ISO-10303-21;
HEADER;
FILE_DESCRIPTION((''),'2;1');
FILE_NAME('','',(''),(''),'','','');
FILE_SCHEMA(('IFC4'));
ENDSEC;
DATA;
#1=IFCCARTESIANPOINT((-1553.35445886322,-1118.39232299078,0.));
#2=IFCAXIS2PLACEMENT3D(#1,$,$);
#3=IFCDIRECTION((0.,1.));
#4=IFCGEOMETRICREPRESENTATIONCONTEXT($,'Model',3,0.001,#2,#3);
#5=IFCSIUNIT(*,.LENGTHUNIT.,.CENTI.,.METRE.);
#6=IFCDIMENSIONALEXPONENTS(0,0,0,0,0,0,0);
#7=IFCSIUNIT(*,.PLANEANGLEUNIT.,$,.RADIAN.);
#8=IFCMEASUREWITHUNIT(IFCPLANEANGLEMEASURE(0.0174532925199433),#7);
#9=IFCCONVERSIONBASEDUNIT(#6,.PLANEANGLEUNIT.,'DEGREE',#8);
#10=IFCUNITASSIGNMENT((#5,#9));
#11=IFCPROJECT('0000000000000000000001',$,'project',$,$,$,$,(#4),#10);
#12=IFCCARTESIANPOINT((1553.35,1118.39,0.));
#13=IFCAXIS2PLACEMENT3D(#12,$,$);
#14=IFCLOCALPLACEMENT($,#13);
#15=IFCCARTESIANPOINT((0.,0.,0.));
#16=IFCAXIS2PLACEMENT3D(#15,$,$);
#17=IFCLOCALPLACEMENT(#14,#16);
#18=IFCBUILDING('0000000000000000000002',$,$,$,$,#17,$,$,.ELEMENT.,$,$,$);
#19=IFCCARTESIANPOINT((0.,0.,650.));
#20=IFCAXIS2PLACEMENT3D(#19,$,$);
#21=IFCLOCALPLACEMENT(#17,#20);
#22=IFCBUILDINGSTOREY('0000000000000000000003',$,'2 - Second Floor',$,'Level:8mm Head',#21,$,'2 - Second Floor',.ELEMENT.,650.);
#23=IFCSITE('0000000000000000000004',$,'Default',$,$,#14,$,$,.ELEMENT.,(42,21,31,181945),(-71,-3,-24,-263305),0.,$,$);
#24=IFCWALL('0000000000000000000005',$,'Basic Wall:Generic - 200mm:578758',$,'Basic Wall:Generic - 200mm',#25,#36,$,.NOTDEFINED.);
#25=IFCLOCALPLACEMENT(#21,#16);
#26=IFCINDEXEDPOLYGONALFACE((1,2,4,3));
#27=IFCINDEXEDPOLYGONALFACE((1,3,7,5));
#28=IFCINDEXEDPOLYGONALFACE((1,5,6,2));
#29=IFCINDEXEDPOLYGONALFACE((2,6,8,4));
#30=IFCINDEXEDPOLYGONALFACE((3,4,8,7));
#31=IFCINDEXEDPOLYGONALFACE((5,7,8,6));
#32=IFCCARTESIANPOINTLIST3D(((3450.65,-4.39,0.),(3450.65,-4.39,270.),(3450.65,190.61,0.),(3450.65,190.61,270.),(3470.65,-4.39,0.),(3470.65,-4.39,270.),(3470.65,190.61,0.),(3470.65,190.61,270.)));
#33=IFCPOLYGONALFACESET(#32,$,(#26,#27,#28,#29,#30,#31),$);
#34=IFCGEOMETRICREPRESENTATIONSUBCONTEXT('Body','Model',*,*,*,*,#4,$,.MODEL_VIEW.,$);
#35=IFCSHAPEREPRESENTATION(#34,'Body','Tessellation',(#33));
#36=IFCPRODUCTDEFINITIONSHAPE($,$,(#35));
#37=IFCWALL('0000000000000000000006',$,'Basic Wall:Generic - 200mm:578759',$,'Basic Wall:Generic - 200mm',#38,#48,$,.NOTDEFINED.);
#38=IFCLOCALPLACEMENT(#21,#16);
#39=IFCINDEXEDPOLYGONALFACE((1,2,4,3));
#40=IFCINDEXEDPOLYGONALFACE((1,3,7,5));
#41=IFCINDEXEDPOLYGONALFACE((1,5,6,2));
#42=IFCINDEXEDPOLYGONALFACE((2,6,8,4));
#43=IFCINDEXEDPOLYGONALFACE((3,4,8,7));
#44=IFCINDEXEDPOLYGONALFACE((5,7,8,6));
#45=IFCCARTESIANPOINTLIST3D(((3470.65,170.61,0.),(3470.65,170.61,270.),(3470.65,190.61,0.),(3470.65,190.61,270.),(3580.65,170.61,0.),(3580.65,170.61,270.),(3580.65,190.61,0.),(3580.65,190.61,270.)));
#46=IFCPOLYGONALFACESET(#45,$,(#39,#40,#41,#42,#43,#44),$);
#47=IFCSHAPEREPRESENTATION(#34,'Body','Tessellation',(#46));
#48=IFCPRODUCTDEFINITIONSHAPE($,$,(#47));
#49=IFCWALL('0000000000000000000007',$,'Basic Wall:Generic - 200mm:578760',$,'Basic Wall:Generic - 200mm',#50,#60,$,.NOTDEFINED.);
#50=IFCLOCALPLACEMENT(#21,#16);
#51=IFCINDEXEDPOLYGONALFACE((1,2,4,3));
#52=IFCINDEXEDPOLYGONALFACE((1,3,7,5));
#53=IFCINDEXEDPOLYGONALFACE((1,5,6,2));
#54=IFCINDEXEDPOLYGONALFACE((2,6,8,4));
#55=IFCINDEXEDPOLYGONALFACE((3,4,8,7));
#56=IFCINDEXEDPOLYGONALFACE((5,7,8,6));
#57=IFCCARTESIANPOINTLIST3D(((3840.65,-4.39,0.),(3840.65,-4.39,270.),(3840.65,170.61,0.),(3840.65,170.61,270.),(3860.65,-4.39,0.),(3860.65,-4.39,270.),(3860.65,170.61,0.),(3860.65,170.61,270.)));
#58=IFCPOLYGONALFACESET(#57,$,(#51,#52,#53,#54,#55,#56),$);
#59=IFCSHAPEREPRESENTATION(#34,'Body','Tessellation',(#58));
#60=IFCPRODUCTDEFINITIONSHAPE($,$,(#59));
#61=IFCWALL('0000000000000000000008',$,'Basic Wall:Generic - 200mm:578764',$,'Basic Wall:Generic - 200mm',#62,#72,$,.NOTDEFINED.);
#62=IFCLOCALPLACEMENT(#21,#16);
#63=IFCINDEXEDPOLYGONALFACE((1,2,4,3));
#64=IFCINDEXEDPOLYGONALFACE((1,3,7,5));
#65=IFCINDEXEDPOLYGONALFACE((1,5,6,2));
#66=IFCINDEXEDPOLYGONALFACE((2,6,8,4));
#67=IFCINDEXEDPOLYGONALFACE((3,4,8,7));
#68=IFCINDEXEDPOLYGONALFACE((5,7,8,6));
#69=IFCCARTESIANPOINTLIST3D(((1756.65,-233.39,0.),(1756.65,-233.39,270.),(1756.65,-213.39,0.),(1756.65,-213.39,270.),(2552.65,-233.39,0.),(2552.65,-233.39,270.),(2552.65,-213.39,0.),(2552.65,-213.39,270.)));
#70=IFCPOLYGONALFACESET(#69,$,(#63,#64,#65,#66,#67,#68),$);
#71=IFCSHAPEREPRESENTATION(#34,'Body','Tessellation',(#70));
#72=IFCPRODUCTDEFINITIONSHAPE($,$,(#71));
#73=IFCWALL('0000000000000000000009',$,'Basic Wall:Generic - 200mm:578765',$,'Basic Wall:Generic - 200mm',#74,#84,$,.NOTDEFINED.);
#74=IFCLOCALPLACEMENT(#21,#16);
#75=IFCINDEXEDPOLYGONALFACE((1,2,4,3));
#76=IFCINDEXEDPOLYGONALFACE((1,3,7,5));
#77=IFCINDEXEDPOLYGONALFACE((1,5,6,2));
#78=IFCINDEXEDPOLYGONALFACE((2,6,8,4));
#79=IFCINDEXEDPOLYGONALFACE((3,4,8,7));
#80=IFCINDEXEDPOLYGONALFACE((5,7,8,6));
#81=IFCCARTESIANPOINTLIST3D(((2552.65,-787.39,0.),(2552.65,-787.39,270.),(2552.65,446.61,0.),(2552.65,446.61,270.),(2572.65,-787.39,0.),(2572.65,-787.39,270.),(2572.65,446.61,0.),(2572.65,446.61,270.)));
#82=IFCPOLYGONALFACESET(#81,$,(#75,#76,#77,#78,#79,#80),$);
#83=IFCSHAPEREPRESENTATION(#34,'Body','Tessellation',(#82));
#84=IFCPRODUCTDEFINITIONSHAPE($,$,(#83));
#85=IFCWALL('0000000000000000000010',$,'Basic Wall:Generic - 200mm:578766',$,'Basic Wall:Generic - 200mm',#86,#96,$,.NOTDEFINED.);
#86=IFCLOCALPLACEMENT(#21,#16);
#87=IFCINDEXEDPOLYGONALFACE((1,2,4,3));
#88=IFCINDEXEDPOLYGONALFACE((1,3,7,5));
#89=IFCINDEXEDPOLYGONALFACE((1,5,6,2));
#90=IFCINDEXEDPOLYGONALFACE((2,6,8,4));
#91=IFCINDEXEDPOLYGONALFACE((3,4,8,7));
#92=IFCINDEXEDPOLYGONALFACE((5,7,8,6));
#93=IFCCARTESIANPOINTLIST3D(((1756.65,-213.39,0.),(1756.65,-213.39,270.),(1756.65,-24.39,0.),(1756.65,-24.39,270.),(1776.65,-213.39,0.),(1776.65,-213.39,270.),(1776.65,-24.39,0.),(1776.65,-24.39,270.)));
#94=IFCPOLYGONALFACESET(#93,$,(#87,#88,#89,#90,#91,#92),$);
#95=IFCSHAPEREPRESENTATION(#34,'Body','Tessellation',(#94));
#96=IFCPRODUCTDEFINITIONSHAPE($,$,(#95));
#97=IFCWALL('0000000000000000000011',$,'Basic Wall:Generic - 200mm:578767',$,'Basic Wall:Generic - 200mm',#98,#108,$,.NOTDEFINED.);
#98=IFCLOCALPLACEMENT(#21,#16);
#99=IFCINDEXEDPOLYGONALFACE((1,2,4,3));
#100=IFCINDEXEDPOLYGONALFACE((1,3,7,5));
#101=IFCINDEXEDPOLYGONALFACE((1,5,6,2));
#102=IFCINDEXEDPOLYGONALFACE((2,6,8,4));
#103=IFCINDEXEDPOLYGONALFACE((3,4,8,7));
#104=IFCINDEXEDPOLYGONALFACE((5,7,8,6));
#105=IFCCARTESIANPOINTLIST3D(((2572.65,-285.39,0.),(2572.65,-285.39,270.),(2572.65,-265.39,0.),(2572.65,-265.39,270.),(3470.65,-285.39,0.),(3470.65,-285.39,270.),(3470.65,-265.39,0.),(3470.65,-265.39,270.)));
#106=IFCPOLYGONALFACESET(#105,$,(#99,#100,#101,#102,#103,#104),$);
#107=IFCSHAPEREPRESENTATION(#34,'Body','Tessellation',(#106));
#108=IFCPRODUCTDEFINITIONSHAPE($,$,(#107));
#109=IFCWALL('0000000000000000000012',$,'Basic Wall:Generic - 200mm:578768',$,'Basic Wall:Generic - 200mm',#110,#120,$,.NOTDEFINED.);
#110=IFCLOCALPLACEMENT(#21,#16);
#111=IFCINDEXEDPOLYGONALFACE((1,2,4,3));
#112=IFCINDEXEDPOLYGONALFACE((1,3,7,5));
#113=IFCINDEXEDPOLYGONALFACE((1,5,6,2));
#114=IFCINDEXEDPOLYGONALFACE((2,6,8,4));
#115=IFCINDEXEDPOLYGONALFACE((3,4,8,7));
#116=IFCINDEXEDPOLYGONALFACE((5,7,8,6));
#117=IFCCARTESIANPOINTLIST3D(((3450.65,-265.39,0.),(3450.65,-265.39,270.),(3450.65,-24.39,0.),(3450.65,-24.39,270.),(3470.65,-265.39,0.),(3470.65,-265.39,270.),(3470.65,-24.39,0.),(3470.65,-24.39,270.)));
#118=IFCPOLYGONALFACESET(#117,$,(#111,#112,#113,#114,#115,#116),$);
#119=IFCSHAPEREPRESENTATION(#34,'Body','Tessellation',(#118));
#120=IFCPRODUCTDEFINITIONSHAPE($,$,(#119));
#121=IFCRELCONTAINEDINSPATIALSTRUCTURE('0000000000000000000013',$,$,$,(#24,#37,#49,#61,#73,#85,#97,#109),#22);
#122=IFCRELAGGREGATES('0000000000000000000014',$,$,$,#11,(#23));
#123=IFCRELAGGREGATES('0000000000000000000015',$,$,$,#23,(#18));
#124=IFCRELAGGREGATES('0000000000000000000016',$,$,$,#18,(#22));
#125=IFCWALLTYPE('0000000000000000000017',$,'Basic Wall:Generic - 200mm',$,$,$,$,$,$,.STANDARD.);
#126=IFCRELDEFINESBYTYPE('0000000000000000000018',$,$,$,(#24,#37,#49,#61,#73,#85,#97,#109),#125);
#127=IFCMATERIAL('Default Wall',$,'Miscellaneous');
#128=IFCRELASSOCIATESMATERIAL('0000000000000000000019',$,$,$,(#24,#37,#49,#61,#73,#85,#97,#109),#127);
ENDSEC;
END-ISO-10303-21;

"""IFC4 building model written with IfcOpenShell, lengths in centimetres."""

from ifc_helpers import new_model, entity, si_unit, converted_unit, direction, frame, origin, place, context, subcontext, project, spatial, indexed_curve, outline, extrude, material, type_object, element, save


model = new_model("IFC4")

# Units and contexts
model_context = context("Model", 3, precision=0.001, world=frame((-1553.35445886322, -1118.39232299078, 0.0)), true_north=direction((0.0, 1.0)))
body_context = subcontext(model_context, "Body", "Model", "MODEL_VIEW")
ifc_project = project(units=[si_unit("LENGTHUNIT", "METRE", prefix="CENTI"), converted_unit("PLANEANGLEUNIT", "DEGREE", entity("IfcPlaneAngleMeasure", 0.0174532925199433), si_unit("PLANEANGLEUNIT", "RADIAN"), dimensions=[0, 0, 0, 0, 0, 0, 0])], contexts=[model_context])

# Site, building, storey
site_placement = place(None, frame((1553.35, 1118.39, 0.0)))
site = spatial("IfcSite", under=ifc_project, at=site_placement, Name="Default", CompositionType="ELEMENT", RefLatitude=(42, 21, 31, 181945), RefLongitude=(-71, -3, -24, -263305), RefElevation=0.0)
building_placement = place(site_placement, origin())
building = spatial("IfcBuilding", under=site, at=building_placement, CompositionType="ELEMENT")
storey_placement = place(building_placement, frame((0.0, 0.0, 650.0)))
storey = spatial("IfcBuildingStorey", under=building, at=storey_placement, Name="2 - Second Floor", ObjectType="Level:8mm Head", LongName="2 - Second Floor", CompositionType="ELEMENT", Elevation=650.0)

# Walls
ifc_material_1 = material(Name="Default Wall", Category="Miscellaneous")
wall_type_1 = type_object("IfcWallType", Name="Basic Wall:Generic - 200mm", PredefinedType="STANDARD")
wall_1_placement = place(storey_placement, frame((3460.65, -4.39, 0.0), z_axis=(0.0, 0.0, 1.0), x_axis=(0.0, 1.0, 0.0)))
element("IfcWall", 1, at=wall_1_placement, inside=storey, type_object=wall_type_1, material=ifc_material_1, Name="Basic Wall:Generic - 200mm:578758", ObjectType="Basic Wall:Generic - 200mm", PredefinedType="NOTDEFINED", context=body_context, shape_type="SweptSolid", body=[
    extrude(outline(indexed_curve([(195.0, 10.0), (0.0, 10.0), (0.0, -10.0), (195.0, -10.0), (195.0, 10.0)], self_intersect=False)), origin(), (0.0, 0.0, 1.0), 270.0),
])
wall_2_placement = place(storey_placement, frame((3470.65, 180.61, 0.0)))
element("IfcWall", 2, at=wall_2_placement, inside=storey, type_object=wall_type_1, material=ifc_material_1, Name="Basic Wall:Generic - 200mm:578759", ObjectType="Basic Wall:Generic - 200mm", PredefinedType="NOTDEFINED", context=body_context, shape_type="SweptSolid", body=[
    extrude(outline(indexed_curve([(110.0, 10.0), (0.0, 10.0), (0.0, -10.0), (110.0, -10.0), (110.0, 10.0)], self_intersect=False)), origin(), (0.0, 0.0, 1.0), 270.0),
])
wall_3_placement = place(storey_placement, frame((3850.65, 170.61, 0.0), z_axis=(0.0, 0.0, 1.0), x_axis=(0.0, -1.0, 0.0)))
element("IfcWall", 3, at=wall_3_placement, inside=storey, type_object=wall_type_1, material=ifc_material_1, Name="Basic Wall:Generic - 200mm:578760", ObjectType="Basic Wall:Generic - 200mm", PredefinedType="NOTDEFINED", context=body_context, shape_type="SweptSolid", body=[
    extrude(outline(indexed_curve([(175.0, 10.0), (0.0, 10.0), (0.0, -10.0), (175.0, -10.0), (175.0, 10.0)], self_intersect=False)), origin(), (0.0, 0.0, 1.0), 270.0),
])
wall_4_placement = place(storey_placement, frame((1756.65, -223.39, 0.0)))
element("IfcWall", 4, at=wall_4_placement, inside=storey, type_object=wall_type_1, material=ifc_material_1, Name="Basic Wall:Generic - 200mm:578764", ObjectType="Basic Wall:Generic - 200mm", PredefinedType="NOTDEFINED", context=body_context, shape_type="SweptSolid", body=[
    extrude(outline(indexed_curve([(796.0, 10.0), (0.0, 10.0), (0.0, -10.0), (796.0, -10.0), (796.0, 10.0)], self_intersect=False)), origin(), (0.0, 0.0, 1.0), 270.0),
])
wall_5_placement = place(storey_placement, frame((2562.65, 446.61, 0.0), z_axis=(0.0, 0.0, 1.0), x_axis=(0.0, -1.0, 0.0)))
element("IfcWall", 5, at=wall_5_placement, inside=storey, type_object=wall_type_1, material=ifc_material_1, Name="Basic Wall:Generic - 200mm:578765", ObjectType="Basic Wall:Generic - 200mm", PredefinedType="NOTDEFINED", context=body_context, shape_type="SweptSolid", body=[
    extrude(outline(indexed_curve([(1234.0, 10.0), (0.0, 10.0), (0.0, -10.0), (1234.0, -10.0), (1234.0, 10.0)], self_intersect=False)), origin(), (0.0, 0.0, 1.0), 270.0),
])
wall_6_placement = place(storey_placement, frame((1766.65, -24.39, 0.0), z_axis=(0.0, 0.0, 1.0), x_axis=(0.0, -1.0, 0.0)))
element("IfcWall", 6, at=wall_6_placement, inside=storey, type_object=wall_type_1, material=ifc_material_1, Name="Basic Wall:Generic - 200mm:578766", ObjectType="Basic Wall:Generic - 200mm", PredefinedType="NOTDEFINED", context=body_context, shape_type="SweptSolid", body=[
    extrude(outline(indexed_curve([(189.0, 10.0), (0.0, 10.0), (0.0, -10.0), (189.0, -10.0), (189.0, 10.0)], self_intersect=False)), origin(), (0.0, 0.0, 1.0), 270.0),
])
wall_7_placement = place(storey_placement, frame((2572.65, -275.39, 0.0)))
element("IfcWall", 7, at=wall_7_placement, inside=storey, type_object=wall_type_1, material=ifc_material_1, Name="Basic Wall:Generic - 200mm:578767", ObjectType="Basic Wall:Generic - 200mm", PredefinedType="NOTDEFINED", context=body_context, shape_type="SweptSolid", body=[
    extrude(outline(indexed_curve([(898.0, 10.0), (0.0, 10.0), (0.0, -10.0), (898.0, -10.0), (898.0, 10.0)], self_intersect=False)), origin(), (0.0, 0.0, 1.0), 270.0),
])
wall_8_placement = place(storey_placement, frame((3460.65, -24.39, 0.0), z_axis=(0.0, 0.0, 1.0), x_axis=(0.0, -1.0, 0.0)))
element("IfcWall", 8, at=wall_8_placement, inside=storey, type_object=wall_type_1, material=ifc_material_1, Name="Basic Wall:Generic - 200mm:578768", ObjectType="Basic Wall:Generic - 200mm", PredefinedType="NOTDEFINED", context=body_context, shape_type="SweptSolid", body=[
    extrude(outline(indexed_curve([(241.0, 10.0), (0.0, 10.0), (0.0, -10.0), (241.0, -10.0), (241.0, 10.0)], self_intersect=False)), origin(), (0.0, 0.0, 1.0), 270.0),
])

save(model, "model.ifc")
